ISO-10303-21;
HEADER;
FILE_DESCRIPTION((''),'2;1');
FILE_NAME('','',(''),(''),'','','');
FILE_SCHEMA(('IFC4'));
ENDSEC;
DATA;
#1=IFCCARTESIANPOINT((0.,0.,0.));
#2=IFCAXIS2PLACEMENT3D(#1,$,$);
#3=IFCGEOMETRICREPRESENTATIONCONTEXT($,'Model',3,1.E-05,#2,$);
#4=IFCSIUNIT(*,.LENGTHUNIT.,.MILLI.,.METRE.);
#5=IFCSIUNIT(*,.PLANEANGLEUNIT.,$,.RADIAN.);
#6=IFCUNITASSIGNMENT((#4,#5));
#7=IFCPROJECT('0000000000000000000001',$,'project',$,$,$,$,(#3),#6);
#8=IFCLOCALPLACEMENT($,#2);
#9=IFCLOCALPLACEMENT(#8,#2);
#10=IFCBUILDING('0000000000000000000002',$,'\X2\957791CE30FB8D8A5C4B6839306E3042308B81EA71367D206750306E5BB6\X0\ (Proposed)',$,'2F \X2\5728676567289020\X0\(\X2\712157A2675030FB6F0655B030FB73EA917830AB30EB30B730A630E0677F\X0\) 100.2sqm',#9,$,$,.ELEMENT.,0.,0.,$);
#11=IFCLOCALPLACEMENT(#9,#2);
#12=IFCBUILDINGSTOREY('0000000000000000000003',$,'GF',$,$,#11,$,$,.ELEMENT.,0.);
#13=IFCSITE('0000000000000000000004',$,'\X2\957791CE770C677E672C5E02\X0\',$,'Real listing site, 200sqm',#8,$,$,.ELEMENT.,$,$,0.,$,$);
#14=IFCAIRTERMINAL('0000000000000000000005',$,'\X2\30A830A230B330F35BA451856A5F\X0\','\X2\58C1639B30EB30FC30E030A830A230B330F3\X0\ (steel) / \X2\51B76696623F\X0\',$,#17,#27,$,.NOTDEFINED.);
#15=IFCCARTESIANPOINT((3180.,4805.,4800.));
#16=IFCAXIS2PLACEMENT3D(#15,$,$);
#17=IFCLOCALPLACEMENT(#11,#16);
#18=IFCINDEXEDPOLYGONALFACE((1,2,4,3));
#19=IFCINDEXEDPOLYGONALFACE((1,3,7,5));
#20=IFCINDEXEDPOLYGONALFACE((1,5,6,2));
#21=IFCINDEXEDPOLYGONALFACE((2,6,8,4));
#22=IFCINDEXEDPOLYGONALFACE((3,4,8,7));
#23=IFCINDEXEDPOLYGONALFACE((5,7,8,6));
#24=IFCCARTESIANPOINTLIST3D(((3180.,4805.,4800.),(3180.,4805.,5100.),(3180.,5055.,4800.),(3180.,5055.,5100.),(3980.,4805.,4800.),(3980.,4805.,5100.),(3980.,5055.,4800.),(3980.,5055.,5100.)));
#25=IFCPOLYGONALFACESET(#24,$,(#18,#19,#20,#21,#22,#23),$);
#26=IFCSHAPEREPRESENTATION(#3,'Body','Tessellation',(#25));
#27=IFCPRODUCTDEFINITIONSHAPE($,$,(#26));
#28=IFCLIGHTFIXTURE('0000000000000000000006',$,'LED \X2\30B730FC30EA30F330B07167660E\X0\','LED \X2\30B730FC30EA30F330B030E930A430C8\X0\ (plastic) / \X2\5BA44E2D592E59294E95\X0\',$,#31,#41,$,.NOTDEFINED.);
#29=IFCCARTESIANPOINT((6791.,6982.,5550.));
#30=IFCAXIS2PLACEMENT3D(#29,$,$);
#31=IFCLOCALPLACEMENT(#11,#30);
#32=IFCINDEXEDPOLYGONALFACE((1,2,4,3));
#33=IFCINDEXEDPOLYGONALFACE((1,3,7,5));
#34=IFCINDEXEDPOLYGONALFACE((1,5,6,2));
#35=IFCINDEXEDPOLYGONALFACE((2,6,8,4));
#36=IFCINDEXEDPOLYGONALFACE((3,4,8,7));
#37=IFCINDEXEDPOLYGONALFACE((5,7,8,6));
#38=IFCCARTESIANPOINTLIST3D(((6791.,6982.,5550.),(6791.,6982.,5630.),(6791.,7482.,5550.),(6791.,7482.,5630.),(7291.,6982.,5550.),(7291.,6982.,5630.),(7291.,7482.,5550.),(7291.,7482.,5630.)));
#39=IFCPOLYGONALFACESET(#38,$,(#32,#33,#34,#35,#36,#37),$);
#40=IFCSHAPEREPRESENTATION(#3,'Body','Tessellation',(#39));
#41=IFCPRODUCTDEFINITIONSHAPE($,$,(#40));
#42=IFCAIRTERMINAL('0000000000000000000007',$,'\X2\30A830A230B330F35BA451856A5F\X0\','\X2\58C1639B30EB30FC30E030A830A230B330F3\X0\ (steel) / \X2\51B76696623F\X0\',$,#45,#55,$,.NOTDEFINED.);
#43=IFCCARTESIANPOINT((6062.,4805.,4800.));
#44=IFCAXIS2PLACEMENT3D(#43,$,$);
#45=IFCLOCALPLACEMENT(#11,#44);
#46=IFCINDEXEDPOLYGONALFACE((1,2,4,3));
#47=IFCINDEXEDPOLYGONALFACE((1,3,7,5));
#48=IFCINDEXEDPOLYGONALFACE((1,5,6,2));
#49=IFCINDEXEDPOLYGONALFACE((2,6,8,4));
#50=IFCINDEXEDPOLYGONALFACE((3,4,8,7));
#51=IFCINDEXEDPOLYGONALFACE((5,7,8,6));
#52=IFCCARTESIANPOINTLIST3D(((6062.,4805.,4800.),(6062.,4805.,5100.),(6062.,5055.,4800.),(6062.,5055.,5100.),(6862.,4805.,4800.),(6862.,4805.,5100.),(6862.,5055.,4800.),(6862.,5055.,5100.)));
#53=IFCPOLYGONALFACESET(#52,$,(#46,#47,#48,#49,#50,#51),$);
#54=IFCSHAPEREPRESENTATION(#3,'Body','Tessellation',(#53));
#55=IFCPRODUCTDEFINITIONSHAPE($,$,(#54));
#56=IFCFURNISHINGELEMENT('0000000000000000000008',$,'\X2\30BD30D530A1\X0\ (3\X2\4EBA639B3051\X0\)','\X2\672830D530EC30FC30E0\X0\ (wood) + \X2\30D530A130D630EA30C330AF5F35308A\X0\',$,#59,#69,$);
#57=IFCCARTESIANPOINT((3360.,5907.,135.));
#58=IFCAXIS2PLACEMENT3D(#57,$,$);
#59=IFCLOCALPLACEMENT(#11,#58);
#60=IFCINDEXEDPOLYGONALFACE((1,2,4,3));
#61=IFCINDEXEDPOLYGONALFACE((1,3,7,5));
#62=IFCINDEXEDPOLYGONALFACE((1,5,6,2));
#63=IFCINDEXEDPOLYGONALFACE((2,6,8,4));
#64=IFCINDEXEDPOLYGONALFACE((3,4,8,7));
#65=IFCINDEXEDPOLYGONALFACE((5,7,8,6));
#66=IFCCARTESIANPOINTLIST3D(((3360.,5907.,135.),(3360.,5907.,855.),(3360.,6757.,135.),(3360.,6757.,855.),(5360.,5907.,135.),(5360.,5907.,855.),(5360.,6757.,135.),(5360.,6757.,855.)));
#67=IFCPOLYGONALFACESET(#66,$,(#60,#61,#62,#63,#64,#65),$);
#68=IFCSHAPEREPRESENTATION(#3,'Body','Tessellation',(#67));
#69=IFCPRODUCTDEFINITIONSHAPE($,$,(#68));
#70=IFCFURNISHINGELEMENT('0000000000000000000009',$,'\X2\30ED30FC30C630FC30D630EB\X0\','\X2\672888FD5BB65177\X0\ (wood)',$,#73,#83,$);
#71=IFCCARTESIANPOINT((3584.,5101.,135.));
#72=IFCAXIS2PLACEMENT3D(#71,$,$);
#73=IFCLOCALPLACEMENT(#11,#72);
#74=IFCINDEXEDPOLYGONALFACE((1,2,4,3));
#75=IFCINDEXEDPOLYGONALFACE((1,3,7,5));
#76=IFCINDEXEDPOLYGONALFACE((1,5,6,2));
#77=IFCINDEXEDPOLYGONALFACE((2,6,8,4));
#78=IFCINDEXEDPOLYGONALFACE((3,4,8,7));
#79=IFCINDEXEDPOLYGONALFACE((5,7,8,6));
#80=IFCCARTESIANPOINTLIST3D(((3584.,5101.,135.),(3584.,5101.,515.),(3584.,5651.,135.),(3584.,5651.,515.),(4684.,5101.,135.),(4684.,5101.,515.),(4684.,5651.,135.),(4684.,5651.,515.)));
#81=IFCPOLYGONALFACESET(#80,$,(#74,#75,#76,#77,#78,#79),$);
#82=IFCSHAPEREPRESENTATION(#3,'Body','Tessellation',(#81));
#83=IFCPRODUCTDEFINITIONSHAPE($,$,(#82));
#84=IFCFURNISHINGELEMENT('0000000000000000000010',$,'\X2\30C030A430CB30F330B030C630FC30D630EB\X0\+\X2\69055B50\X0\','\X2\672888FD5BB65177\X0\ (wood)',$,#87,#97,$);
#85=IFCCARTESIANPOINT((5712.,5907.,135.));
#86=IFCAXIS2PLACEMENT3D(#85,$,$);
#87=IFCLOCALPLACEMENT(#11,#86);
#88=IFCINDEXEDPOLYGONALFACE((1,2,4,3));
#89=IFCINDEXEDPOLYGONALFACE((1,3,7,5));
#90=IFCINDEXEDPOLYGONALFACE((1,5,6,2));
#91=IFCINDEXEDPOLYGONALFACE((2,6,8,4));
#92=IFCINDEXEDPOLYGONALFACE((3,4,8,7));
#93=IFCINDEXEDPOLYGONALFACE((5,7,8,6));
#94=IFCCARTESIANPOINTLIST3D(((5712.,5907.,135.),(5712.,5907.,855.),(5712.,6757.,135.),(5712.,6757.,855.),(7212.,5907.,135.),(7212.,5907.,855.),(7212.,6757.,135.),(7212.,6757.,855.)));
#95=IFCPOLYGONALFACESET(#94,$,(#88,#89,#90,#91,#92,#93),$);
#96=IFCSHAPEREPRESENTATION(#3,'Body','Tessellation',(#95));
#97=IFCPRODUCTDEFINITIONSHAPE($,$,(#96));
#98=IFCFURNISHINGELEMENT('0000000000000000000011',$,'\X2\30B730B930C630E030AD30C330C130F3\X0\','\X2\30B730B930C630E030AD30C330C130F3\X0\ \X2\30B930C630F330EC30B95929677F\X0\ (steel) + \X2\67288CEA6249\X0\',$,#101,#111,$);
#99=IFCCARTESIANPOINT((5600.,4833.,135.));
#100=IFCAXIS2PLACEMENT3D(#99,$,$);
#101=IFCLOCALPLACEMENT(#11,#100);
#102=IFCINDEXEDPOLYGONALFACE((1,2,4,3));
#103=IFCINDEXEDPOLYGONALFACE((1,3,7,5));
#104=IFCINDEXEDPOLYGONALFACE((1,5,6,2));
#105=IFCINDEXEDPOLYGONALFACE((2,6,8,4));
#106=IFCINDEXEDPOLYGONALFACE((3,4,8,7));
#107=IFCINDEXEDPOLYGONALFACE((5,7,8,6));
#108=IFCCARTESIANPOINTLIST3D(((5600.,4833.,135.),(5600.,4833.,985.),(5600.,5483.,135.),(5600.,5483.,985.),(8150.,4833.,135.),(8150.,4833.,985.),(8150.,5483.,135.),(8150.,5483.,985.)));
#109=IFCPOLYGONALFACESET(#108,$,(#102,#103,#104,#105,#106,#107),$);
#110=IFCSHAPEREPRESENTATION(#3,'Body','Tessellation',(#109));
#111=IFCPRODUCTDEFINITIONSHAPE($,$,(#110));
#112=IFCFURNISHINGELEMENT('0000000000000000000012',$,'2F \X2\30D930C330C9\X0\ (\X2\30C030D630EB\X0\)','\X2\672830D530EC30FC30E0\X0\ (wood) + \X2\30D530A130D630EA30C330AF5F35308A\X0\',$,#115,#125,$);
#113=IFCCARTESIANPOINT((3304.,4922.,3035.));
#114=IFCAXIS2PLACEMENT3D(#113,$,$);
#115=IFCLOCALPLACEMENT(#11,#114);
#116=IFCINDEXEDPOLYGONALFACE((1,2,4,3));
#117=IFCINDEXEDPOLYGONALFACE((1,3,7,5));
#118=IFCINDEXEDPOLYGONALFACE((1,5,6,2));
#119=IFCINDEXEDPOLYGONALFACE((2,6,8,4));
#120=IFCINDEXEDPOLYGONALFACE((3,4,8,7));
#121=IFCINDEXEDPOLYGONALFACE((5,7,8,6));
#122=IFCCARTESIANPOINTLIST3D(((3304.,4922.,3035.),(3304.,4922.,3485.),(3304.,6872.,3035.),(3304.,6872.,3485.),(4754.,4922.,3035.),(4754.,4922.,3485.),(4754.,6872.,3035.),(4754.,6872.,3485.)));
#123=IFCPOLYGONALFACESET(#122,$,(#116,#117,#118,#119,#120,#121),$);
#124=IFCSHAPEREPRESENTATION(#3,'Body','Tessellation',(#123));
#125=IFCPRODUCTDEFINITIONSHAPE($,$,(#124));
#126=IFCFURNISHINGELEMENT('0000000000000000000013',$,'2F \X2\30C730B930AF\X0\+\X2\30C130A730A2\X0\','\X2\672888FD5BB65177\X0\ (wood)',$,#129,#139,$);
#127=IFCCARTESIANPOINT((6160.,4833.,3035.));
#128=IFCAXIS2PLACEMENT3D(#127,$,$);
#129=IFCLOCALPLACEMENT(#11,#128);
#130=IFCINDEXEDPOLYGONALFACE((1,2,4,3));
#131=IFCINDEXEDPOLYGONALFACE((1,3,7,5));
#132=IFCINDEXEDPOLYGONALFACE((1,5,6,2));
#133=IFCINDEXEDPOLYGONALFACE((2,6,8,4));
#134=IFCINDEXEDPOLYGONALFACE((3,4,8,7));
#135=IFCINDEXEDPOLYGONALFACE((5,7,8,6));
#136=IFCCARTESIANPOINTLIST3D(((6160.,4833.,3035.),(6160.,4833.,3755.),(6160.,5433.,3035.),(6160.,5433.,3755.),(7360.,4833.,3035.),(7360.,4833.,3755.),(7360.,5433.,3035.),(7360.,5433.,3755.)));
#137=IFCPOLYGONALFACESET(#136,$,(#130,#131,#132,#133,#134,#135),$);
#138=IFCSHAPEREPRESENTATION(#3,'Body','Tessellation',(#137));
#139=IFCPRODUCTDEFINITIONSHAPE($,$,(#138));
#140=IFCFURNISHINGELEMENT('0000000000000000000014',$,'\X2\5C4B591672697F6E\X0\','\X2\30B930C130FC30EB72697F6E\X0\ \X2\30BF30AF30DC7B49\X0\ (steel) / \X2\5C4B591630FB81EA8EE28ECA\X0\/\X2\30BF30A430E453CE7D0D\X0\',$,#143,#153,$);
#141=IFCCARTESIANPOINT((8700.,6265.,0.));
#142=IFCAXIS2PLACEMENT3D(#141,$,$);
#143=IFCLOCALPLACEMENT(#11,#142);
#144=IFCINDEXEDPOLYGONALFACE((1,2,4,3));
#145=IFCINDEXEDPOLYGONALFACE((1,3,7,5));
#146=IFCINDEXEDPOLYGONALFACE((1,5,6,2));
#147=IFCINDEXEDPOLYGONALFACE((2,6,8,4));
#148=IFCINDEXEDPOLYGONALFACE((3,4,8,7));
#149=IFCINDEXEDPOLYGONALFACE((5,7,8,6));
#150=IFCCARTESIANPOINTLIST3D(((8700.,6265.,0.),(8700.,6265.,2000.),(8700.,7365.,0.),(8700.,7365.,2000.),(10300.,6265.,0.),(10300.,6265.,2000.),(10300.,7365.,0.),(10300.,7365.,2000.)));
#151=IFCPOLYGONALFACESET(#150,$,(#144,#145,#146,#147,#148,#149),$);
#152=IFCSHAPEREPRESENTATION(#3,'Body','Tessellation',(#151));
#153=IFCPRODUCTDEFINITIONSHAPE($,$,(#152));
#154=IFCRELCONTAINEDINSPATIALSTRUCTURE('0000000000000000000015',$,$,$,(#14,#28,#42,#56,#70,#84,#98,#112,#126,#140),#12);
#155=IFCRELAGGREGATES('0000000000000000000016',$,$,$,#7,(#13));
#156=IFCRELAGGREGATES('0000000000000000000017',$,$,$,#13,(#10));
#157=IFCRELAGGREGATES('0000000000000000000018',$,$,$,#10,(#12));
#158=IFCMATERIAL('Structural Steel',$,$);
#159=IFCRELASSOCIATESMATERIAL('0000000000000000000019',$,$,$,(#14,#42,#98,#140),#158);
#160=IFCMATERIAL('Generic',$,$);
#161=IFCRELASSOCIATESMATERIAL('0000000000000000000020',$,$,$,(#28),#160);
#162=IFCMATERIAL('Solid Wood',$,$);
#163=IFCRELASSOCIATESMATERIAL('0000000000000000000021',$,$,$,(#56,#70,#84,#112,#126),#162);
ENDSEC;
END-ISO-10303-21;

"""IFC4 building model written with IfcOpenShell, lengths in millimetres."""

from ifc_helpers import new_model, si_unit, frame, frame_2d, origin, place, context, project, spatial, rectangle, extrude, material, element, save


model = new_model("IFC4")

# Units and contexts
model_context = context("Model", 3, precision=1e-05, world=origin())
ifc_project = project(units=[si_unit("LENGTHUNIT", "METRE", prefix="MILLI"), si_unit("PLANEANGLEUNIT", "RADIAN")], contexts=[model_context])

# Site, building, storey
site_placement = place(None, origin())
site = spatial("IfcSite", under=ifc_project, at=site_placement, Name="長野県松本市", ObjectType="Real listing site, 200sqm", CompositionType="ELEMENT", RefElevation=0.0)
building_placement = place(site_placement, origin())
building = spatial("IfcBuilding", under=site, at=building_placement, Name="長野・越屋根のある自然素材の家 (Proposed)", ObjectType="2F 在来木造(無垢材・漆喰・珪酸カルシウム板) 100.2sqm", CompositionType="ELEMENT", ElevationOfRefHeight=0.0, ElevationOfTerrain=0.0)
storey_placement = place(building_placement, origin())
storey = spatial("IfcBuildingStorey", under=building, at=storey_placement, Name="GF", CompositionType="ELEMENT", Elevation=0.0)

# Shared definitions
ifc_material_1 = material(Name="Solid Wood")

# Shared definitions
ifc_material_2 = material(Name="Generic")

# Shared definitions
ifc_material_3 = material(Name="Structural Steel")

# Air terminal
air_terminal_1_placement = place(storey_placement, frame((3180.0, 4805.0, 4800.0)))
element("IfcAirTerminal", 1, at=air_terminal_1_placement, inside=storey, material=ifc_material_3, Name="エアコン室内機", Description="壁掛ルームエアコン (steel) / 冷暖房", PredefinedType="NOTDEFINED", context=model_context, shape_type="SweptSolid", body=[
    extrude(rectangle(XDim=800.0, YDim=250.0, at=frame_2d((400.0, 125.0))), frame((3180.0, 4805.0, 4800.0)), (0.0, 0.0, 1.0), 300.0),
])

# Light fixture
light_fixture_1_placement = place(storey_placement, frame((6791.0, 6982.0, 5550.0)))
element("IfcLightFixture", 2, at=light_fixture_1_placement, inside=storey, material=ifc_material_2, Name="LED シーリング照明", Description="LED シーリングライト (plastic) / 室中央天井", PredefinedType="NOTDEFINED", context=model_context, shape_type="SweptSolid", body=[
    extrude(rectangle(XDim=500.0, YDim=500.0, at=frame_2d((250.0, 250.0))), frame((6791.0, 6982.0, 5550.0)), (0.0, 0.0, 1.0), 80.0),
])

# Air terminal
air_terminal_2_placement = place(storey_placement, frame((6062.0, 4805.0, 4800.0)))
element("IfcAirTerminal", 3, at=air_terminal_2_placement, inside=storey, material=ifc_material_3, Name="エアコン室内機", Description="壁掛ルームエアコン (steel) / 冷暖房", PredefinedType="NOTDEFINED", context=model_context, shape_type="SweptSolid", body=[
    extrude(rectangle(XDim=800.0, YDim=250.0, at=frame_2d((400.0, 125.0))), frame((6062.0, 4805.0, 4800.0)), (0.0, 0.0, 1.0), 300.0),
])

# Furnishing elements
furnishing_1_placement = place(storey_placement, frame((3360.0, 5907.0, 135.0)))
element("IfcFurnishingElement", 4, at=furnishing_1_placement, inside=storey, material=ifc_material_1, Name="ソファ (3人掛け)", Description="木フレーム (wood) + ファブリック張り", context=model_context, shape_type="SweptSolid", body=[
    extrude(rectangle(XDim=2000.0, YDim=850.0, at=frame_2d((1000.0, 425.0))), frame((3360.0, 5907.0, 135.0)), (0.0, 0.0, 1.0), 720.0),
])
furnishing_2_placement = place(storey_placement, frame((3584.0, 5101.0, 135.0)))
element("IfcFurnishingElement", 5, at=furnishing_2_placement, inside=storey, material=ifc_material_1, Name="ローテーブル", Description="木製家具 (wood)", context=model_context, shape_type="SweptSolid", body=[
    extrude(rectangle(XDim=1100.0, YDim=550.0, at=frame_2d((550.0, 275.0))), frame((3584.0, 5101.0, 135.0)), (0.0, 0.0, 1.0), 380.0),
])
furnishing_3_placement = place(storey_placement, frame((5712.0, 5907.0, 135.0)))
element("IfcFurnishingElement", 6, at=furnishing_3_placement, inside=storey, material=ifc_material_1, Name="ダイニングテーブル+椅子", Description="木製家具 (wood)", context=model_context, shape_type="SweptSolid", body=[
    extrude(rectangle(XDim=1500.0, YDim=850.0, at=frame_2d((750.0, 425.0))), frame((5712.0, 5907.0, 135.0)), (0.0, 0.0, 1.0), 720.0),
])
furnishing_4_placement = place(storey_placement, frame((5600.0, 4833.0, 135.0)))
element("IfcFurnishingElement", 7, at=furnishing_4_placement, inside=storey, material=ifc_material_3, Name="システムキッチン", Description="システムキッチン ステンレス天板 (steel) + 木質扉", context=model_context, shape_type="SweptSolid", body=[
    extrude(rectangle(XDim=2550.0, YDim=650.0, at=frame_2d((1275.0, 325.0))), frame((5600.0, 4833.0, 135.0)), (0.0, 0.0, 1.0), 850.0),
])
furnishing_5_placement = place(storey_placement, frame((3304.0, 4922.0, 3035.0)))
element("IfcFurnishingElement", 8, at=furnishing_5_placement, inside=storey, material=ifc_material_1, Name="2F ベッド (ダブル)", Description="木フレーム (wood) + ファブリック張り", context=model_context, shape_type="SweptSolid", body=[
    extrude(rectangle(XDim=1450.0, YDim=1950.0, at=frame_2d((725.0, 975.0))), frame((3304.0, 4922.0, 3035.0)), (0.0, 0.0, 1.0), 450.0),
])
furnishing_6_placement = place(storey_placement, frame((6160.0, 4833.0, 3035.0)))
element("IfcFurnishingElement", 9, at=furnishing_6_placement, inside=storey, material=ifc_material_1, Name="2F デスク+チェア", Description="木製家具 (wood)", context=model_context, shape_type="SweptSolid", body=[
    extrude(rectangle(XDim=1200.0, YDim=600.0, at=frame_2d((600.0, 300.0))), frame((6160.0, 4833.0, 3035.0)), (0.0, 0.0, 1.0), 720.0),
])
furnishing_7_placement = place(storey_placement, frame((8700.0, 6265.0, 0.0)))
element("IfcFurnishingElement", 10, at=furnishing_7_placement, inside=storey, material=ifc_material_3, Name="屋外物置", Description="スチール物置 タクボ等 (steel) / 屋外・自転車/タイヤ収納", context=model_context, shape_type="SweptSolid", body=[
    extrude(rectangle(XDim=1600.0, YDim=1100.0, at=frame_2d((800.0, 550.0))), frame((8700.0, 6265.0, 0.0)), (0.0, 0.0, 1.0), 2000.0),
])

save(model, "model.ifc")
